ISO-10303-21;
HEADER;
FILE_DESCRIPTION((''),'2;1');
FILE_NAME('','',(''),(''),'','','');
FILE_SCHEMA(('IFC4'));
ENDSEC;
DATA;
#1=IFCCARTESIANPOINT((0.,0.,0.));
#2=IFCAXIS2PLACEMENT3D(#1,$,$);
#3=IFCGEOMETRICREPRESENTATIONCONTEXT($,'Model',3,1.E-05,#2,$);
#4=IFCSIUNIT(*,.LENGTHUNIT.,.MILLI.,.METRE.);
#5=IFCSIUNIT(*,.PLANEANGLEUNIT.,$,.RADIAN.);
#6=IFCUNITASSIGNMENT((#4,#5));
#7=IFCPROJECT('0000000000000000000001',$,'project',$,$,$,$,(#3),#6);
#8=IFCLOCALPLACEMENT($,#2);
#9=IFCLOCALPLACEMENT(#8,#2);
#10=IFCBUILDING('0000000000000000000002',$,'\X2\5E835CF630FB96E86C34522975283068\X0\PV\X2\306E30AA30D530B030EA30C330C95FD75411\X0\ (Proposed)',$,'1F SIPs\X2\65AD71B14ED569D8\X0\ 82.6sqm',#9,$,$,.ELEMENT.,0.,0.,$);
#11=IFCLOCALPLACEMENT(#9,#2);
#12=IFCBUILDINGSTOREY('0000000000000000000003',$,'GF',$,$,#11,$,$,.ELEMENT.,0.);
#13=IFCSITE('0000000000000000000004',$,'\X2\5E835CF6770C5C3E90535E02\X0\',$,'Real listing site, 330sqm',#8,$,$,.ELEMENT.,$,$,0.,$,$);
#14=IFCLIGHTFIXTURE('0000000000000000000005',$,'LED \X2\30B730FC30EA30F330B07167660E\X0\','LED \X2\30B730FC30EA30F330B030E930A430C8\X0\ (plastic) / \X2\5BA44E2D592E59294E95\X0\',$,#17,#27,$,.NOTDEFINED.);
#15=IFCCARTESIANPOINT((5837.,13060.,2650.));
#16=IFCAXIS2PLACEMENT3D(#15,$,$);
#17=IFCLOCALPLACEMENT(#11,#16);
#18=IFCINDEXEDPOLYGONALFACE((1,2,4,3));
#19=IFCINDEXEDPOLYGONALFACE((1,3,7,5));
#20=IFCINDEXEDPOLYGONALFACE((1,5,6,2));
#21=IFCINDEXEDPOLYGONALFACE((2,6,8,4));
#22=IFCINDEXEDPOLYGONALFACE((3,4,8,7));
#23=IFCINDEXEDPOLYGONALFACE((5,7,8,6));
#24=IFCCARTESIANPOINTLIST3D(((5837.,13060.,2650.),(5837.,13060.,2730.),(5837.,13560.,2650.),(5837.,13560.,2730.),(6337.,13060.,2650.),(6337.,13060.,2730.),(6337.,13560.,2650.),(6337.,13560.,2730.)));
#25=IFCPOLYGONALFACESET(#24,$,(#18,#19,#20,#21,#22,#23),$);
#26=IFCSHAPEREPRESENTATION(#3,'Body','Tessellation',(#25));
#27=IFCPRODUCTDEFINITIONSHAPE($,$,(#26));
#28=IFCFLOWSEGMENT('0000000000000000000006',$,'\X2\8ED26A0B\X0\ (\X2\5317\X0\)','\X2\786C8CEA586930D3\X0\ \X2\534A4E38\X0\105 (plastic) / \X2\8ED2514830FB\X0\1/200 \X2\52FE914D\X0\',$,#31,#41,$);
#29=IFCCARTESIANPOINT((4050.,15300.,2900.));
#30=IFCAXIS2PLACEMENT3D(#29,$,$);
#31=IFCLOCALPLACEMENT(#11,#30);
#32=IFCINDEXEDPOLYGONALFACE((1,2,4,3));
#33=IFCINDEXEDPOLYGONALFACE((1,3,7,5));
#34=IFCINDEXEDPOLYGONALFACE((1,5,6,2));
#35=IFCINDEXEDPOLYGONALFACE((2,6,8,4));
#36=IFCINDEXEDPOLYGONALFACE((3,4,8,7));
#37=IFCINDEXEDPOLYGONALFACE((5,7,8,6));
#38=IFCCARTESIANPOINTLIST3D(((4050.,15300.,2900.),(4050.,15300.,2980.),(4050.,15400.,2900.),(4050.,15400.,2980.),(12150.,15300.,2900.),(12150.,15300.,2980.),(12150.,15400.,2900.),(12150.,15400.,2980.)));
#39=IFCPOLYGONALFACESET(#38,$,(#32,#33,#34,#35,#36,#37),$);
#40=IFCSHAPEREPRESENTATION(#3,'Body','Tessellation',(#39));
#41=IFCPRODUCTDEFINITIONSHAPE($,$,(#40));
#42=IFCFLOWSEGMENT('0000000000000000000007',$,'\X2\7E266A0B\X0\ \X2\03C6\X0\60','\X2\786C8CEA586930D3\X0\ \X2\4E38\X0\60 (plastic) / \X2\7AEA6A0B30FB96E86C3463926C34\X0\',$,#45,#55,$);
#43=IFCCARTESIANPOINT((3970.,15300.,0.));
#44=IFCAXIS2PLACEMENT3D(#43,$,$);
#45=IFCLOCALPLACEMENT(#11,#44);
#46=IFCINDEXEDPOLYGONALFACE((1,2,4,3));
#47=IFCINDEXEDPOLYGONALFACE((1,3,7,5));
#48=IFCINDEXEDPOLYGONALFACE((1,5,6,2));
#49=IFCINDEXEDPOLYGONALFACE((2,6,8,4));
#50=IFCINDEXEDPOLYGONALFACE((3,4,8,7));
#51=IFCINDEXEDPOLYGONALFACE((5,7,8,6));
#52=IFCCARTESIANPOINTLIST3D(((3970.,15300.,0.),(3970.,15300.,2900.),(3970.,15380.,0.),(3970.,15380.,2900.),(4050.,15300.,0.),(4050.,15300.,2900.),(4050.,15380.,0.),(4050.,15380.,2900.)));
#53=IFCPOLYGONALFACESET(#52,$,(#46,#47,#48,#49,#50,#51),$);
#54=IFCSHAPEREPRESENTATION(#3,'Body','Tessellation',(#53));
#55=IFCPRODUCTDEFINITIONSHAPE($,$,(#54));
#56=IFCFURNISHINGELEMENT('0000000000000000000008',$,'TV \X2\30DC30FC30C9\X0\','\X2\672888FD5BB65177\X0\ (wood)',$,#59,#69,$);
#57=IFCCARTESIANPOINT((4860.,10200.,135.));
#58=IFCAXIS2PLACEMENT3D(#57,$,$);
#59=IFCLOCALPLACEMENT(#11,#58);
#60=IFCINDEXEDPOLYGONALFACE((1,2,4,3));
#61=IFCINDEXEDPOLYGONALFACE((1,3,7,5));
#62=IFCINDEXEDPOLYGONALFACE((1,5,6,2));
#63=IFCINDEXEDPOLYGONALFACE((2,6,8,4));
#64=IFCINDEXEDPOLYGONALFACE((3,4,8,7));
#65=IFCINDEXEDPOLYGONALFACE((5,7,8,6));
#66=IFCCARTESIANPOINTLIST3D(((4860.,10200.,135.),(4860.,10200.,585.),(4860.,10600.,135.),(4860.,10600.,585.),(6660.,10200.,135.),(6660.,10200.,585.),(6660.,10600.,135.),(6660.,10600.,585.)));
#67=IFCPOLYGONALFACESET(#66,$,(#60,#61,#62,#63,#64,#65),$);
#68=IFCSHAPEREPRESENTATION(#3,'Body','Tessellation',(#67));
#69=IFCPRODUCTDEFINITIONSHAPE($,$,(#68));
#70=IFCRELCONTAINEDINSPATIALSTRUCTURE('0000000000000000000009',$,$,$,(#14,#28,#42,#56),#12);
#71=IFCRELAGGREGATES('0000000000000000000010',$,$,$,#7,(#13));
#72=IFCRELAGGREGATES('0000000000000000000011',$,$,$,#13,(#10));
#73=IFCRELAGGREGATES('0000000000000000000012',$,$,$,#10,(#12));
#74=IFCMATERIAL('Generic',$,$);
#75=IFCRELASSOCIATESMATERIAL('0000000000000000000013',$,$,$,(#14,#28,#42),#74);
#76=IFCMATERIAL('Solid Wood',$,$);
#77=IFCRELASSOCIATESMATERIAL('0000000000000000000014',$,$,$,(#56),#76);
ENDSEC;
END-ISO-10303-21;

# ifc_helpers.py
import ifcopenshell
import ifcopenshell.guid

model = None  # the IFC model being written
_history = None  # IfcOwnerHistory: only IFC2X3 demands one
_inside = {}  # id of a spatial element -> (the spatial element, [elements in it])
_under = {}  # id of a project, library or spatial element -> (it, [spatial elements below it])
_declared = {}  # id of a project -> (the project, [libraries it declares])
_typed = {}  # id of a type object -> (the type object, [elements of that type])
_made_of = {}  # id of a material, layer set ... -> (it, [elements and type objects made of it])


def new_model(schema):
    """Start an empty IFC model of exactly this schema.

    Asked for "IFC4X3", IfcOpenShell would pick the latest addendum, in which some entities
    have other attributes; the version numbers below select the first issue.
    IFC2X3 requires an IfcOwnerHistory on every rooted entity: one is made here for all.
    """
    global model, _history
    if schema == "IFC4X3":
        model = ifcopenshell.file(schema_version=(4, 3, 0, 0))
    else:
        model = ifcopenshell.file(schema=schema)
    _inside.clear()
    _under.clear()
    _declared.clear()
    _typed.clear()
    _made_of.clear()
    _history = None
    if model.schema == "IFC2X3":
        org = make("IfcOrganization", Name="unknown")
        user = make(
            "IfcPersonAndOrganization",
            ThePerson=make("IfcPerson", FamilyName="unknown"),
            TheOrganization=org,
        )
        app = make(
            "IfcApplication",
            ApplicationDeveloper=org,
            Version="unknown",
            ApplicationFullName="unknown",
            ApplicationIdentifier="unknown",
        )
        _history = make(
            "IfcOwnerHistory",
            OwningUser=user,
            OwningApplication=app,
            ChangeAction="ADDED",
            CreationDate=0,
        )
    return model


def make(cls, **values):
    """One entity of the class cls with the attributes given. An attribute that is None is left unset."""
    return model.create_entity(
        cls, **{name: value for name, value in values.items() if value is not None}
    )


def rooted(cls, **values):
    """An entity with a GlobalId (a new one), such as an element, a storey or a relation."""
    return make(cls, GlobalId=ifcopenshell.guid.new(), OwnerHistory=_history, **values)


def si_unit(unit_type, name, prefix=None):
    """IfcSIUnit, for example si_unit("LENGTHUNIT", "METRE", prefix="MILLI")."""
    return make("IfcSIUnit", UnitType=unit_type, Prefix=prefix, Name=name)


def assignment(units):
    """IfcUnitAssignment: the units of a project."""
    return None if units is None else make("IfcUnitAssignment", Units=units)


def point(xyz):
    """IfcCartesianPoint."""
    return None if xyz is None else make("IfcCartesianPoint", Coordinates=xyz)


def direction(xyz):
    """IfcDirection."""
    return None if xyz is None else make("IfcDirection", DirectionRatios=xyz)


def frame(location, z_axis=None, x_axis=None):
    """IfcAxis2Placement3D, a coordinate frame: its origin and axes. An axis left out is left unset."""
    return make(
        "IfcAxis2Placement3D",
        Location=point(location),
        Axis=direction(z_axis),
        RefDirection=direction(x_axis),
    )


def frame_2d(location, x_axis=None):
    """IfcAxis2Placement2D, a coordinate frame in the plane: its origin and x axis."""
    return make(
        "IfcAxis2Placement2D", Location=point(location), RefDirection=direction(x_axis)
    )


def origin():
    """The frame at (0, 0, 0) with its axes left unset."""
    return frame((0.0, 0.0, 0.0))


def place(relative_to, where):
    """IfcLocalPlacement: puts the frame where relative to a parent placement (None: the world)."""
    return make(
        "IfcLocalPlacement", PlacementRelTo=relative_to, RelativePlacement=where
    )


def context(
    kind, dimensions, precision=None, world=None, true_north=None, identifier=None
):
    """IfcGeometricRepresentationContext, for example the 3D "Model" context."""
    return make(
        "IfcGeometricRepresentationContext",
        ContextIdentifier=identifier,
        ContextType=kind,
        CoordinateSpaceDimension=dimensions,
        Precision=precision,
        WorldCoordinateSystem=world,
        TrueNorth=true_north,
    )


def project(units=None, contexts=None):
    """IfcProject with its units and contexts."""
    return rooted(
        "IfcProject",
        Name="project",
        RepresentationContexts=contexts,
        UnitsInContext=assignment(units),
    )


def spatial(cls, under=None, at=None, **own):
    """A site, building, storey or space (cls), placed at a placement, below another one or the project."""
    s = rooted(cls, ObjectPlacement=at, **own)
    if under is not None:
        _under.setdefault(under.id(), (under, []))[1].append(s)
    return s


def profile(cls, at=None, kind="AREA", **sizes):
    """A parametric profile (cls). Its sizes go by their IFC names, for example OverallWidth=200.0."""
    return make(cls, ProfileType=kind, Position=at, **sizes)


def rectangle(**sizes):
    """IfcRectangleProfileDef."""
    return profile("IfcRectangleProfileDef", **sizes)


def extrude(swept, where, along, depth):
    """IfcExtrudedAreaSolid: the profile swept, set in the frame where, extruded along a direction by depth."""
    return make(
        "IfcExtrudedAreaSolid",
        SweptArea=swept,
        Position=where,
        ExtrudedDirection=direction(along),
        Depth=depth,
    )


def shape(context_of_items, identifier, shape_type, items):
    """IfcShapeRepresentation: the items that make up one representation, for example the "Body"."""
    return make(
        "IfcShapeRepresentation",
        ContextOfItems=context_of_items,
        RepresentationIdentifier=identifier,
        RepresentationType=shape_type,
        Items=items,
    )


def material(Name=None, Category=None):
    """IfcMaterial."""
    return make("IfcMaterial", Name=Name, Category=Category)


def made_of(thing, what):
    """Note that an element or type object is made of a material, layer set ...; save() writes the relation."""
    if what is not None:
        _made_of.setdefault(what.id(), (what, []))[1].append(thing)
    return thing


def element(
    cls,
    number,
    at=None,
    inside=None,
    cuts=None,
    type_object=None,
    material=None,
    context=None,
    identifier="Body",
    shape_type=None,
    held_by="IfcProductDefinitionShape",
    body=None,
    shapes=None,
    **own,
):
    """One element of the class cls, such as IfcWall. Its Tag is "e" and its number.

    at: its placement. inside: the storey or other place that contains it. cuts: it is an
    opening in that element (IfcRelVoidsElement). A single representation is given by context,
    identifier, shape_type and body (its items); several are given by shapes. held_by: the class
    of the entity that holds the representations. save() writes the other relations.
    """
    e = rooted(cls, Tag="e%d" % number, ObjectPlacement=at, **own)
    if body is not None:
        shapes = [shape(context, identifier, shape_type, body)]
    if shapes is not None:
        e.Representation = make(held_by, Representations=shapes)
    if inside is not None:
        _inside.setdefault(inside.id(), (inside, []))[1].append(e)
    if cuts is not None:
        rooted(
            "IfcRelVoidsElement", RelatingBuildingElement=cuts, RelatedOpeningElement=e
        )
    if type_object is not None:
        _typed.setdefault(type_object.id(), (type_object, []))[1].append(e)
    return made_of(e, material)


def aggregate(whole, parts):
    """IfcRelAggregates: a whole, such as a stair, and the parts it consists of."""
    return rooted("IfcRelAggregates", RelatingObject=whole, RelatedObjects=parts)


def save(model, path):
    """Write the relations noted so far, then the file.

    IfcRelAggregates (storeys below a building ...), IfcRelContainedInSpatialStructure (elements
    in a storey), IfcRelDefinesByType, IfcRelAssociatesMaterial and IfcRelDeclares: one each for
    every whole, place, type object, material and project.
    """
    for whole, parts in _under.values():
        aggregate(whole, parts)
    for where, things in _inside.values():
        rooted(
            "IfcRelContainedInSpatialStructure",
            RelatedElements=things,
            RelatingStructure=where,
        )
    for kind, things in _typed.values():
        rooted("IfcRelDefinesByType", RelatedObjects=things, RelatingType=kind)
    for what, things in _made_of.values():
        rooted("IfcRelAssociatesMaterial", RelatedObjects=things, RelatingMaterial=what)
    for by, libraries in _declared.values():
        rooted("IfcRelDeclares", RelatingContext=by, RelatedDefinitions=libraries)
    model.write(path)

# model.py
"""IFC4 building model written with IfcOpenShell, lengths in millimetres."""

from ifc_helpers import new_model, si_unit, frame, frame_2d, origin, place, context, project, spatial, rectangle, extrude, material, element, save


model = new_model("IFC4")

# Units and contexts
model_context = context("Model", 3, precision=1e-05, world=origin())
ifc_project = project(units=[si_unit("LENGTHUNIT", "METRE", prefix="MILLI"), si_unit("PLANEANGLEUNIT", "RADIAN")], contexts=[model_context])

# Site, building, storey
site_placement = place(None, origin())
site = spatial("IfcSite", under=ifc_project, at=site_placement, Name="広島県尾道市", ObjectType="Real listing site, 330sqm", CompositionType="ELEMENT", RefElevation=0.0)
building_placement = place(site_placement, origin())
building = spatial("IfcBuilding", under=site, at=building_placement, Name="広島・雨水利用とPVのオフグリッド志向 (Proposed)", ObjectType="1F SIPs断熱仕様 82.6sqm", CompositionType="ELEMENT", ElevationOfRefHeight=0.0, ElevationOfTerrain=0.0)
storey_placement = place(building_placement, origin())
storey = spatial("IfcBuildingStorey", under=building, at=storey_placement, Name="GF", CompositionType="ELEMENT", Elevation=0.0)

# Shared definitions
ifc_material_1 = material(Name="Solid Wood")

# Shared definitions
ifc_material_2 = material(Name="Generic")

# Light fixture
light_fixture_placement = place(storey_placement, frame((5837.0, 13060.0, 2650.0)))
element("IfcLightFixture", 1, at=light_fixture_placement, inside=storey, material=ifc_material_2, Name="LED シーリング照明", Description="LED シーリングライト (plastic) / 室中央天井", PredefinedType="NOTDEFINED", context=model_context, shape_type="SweptSolid", body=[
    extrude(rectangle(XDim=500.0, YDim=500.0, at=frame_2d((250.0, 250.0))), frame((5837.0, 13060.0, 2650.0)), (0.0, 0.0, 1.0), 80.0),
])

# Flow segments
flow_segment_1_placement = place(storey_placement, frame((4050.0, 15300.0, 2900.0)))
element("IfcFlowSegment", 2, at=flow_segment_1_placement, inside=storey, material=ifc_material_2, Name="軒樋 (北)", Description="硬質塩ビ 半丸105 (plastic) / 軒先・1/200 勾配", context=model_context, shape_type="SweptSolid", body=[
    extrude(rectangle(XDim=8100.0, YDim=100.0, at=frame_2d((4050.0, 50.0))), frame((4050.0, 15300.0, 2900.0)), (0.0, 0.0, 1.0), 80.0),
])
flow_segment_2_placement = place(storey_placement, frame((3970.0, 15300.0, 0.0)))
element("IfcFlowSegment", 3, at=flow_segment_2_placement, inside=storey, material=ifc_material_2, Name="縦樋 φ60", Description="硬質塩ビ 丸60 (plastic) / 竪樋・雨水排水", context=model_context, shape_type="SweptSolid", body=[
    extrude(rectangle(XDim=80.0, YDim=80.0, at=frame_2d((40.0, 40.0))), frame((3970.0, 15300.0, 0.0)), (0.0, 0.0, 1.0), 2900.0),
])

# Furnishing element
furnishing_placement = place(storey_placement, frame((4860.0, 10200.0, 135.0)))
element("IfcFurnishingElement", 4, at=furnishing_placement, inside=storey, material=ifc_material_1, Name="TV ボード", Description="木製家具 (wood)", context=model_context, shape_type="SweptSolid", body=[
    extrude(rectangle(XDim=1800.0, YDim=400.0, at=frame_2d((900.0, 200.0))), frame((4860.0, 10200.0, 135.0)), (0.0, 0.0, 1.0), 450.0),
])

save(model, "model.ifc")
